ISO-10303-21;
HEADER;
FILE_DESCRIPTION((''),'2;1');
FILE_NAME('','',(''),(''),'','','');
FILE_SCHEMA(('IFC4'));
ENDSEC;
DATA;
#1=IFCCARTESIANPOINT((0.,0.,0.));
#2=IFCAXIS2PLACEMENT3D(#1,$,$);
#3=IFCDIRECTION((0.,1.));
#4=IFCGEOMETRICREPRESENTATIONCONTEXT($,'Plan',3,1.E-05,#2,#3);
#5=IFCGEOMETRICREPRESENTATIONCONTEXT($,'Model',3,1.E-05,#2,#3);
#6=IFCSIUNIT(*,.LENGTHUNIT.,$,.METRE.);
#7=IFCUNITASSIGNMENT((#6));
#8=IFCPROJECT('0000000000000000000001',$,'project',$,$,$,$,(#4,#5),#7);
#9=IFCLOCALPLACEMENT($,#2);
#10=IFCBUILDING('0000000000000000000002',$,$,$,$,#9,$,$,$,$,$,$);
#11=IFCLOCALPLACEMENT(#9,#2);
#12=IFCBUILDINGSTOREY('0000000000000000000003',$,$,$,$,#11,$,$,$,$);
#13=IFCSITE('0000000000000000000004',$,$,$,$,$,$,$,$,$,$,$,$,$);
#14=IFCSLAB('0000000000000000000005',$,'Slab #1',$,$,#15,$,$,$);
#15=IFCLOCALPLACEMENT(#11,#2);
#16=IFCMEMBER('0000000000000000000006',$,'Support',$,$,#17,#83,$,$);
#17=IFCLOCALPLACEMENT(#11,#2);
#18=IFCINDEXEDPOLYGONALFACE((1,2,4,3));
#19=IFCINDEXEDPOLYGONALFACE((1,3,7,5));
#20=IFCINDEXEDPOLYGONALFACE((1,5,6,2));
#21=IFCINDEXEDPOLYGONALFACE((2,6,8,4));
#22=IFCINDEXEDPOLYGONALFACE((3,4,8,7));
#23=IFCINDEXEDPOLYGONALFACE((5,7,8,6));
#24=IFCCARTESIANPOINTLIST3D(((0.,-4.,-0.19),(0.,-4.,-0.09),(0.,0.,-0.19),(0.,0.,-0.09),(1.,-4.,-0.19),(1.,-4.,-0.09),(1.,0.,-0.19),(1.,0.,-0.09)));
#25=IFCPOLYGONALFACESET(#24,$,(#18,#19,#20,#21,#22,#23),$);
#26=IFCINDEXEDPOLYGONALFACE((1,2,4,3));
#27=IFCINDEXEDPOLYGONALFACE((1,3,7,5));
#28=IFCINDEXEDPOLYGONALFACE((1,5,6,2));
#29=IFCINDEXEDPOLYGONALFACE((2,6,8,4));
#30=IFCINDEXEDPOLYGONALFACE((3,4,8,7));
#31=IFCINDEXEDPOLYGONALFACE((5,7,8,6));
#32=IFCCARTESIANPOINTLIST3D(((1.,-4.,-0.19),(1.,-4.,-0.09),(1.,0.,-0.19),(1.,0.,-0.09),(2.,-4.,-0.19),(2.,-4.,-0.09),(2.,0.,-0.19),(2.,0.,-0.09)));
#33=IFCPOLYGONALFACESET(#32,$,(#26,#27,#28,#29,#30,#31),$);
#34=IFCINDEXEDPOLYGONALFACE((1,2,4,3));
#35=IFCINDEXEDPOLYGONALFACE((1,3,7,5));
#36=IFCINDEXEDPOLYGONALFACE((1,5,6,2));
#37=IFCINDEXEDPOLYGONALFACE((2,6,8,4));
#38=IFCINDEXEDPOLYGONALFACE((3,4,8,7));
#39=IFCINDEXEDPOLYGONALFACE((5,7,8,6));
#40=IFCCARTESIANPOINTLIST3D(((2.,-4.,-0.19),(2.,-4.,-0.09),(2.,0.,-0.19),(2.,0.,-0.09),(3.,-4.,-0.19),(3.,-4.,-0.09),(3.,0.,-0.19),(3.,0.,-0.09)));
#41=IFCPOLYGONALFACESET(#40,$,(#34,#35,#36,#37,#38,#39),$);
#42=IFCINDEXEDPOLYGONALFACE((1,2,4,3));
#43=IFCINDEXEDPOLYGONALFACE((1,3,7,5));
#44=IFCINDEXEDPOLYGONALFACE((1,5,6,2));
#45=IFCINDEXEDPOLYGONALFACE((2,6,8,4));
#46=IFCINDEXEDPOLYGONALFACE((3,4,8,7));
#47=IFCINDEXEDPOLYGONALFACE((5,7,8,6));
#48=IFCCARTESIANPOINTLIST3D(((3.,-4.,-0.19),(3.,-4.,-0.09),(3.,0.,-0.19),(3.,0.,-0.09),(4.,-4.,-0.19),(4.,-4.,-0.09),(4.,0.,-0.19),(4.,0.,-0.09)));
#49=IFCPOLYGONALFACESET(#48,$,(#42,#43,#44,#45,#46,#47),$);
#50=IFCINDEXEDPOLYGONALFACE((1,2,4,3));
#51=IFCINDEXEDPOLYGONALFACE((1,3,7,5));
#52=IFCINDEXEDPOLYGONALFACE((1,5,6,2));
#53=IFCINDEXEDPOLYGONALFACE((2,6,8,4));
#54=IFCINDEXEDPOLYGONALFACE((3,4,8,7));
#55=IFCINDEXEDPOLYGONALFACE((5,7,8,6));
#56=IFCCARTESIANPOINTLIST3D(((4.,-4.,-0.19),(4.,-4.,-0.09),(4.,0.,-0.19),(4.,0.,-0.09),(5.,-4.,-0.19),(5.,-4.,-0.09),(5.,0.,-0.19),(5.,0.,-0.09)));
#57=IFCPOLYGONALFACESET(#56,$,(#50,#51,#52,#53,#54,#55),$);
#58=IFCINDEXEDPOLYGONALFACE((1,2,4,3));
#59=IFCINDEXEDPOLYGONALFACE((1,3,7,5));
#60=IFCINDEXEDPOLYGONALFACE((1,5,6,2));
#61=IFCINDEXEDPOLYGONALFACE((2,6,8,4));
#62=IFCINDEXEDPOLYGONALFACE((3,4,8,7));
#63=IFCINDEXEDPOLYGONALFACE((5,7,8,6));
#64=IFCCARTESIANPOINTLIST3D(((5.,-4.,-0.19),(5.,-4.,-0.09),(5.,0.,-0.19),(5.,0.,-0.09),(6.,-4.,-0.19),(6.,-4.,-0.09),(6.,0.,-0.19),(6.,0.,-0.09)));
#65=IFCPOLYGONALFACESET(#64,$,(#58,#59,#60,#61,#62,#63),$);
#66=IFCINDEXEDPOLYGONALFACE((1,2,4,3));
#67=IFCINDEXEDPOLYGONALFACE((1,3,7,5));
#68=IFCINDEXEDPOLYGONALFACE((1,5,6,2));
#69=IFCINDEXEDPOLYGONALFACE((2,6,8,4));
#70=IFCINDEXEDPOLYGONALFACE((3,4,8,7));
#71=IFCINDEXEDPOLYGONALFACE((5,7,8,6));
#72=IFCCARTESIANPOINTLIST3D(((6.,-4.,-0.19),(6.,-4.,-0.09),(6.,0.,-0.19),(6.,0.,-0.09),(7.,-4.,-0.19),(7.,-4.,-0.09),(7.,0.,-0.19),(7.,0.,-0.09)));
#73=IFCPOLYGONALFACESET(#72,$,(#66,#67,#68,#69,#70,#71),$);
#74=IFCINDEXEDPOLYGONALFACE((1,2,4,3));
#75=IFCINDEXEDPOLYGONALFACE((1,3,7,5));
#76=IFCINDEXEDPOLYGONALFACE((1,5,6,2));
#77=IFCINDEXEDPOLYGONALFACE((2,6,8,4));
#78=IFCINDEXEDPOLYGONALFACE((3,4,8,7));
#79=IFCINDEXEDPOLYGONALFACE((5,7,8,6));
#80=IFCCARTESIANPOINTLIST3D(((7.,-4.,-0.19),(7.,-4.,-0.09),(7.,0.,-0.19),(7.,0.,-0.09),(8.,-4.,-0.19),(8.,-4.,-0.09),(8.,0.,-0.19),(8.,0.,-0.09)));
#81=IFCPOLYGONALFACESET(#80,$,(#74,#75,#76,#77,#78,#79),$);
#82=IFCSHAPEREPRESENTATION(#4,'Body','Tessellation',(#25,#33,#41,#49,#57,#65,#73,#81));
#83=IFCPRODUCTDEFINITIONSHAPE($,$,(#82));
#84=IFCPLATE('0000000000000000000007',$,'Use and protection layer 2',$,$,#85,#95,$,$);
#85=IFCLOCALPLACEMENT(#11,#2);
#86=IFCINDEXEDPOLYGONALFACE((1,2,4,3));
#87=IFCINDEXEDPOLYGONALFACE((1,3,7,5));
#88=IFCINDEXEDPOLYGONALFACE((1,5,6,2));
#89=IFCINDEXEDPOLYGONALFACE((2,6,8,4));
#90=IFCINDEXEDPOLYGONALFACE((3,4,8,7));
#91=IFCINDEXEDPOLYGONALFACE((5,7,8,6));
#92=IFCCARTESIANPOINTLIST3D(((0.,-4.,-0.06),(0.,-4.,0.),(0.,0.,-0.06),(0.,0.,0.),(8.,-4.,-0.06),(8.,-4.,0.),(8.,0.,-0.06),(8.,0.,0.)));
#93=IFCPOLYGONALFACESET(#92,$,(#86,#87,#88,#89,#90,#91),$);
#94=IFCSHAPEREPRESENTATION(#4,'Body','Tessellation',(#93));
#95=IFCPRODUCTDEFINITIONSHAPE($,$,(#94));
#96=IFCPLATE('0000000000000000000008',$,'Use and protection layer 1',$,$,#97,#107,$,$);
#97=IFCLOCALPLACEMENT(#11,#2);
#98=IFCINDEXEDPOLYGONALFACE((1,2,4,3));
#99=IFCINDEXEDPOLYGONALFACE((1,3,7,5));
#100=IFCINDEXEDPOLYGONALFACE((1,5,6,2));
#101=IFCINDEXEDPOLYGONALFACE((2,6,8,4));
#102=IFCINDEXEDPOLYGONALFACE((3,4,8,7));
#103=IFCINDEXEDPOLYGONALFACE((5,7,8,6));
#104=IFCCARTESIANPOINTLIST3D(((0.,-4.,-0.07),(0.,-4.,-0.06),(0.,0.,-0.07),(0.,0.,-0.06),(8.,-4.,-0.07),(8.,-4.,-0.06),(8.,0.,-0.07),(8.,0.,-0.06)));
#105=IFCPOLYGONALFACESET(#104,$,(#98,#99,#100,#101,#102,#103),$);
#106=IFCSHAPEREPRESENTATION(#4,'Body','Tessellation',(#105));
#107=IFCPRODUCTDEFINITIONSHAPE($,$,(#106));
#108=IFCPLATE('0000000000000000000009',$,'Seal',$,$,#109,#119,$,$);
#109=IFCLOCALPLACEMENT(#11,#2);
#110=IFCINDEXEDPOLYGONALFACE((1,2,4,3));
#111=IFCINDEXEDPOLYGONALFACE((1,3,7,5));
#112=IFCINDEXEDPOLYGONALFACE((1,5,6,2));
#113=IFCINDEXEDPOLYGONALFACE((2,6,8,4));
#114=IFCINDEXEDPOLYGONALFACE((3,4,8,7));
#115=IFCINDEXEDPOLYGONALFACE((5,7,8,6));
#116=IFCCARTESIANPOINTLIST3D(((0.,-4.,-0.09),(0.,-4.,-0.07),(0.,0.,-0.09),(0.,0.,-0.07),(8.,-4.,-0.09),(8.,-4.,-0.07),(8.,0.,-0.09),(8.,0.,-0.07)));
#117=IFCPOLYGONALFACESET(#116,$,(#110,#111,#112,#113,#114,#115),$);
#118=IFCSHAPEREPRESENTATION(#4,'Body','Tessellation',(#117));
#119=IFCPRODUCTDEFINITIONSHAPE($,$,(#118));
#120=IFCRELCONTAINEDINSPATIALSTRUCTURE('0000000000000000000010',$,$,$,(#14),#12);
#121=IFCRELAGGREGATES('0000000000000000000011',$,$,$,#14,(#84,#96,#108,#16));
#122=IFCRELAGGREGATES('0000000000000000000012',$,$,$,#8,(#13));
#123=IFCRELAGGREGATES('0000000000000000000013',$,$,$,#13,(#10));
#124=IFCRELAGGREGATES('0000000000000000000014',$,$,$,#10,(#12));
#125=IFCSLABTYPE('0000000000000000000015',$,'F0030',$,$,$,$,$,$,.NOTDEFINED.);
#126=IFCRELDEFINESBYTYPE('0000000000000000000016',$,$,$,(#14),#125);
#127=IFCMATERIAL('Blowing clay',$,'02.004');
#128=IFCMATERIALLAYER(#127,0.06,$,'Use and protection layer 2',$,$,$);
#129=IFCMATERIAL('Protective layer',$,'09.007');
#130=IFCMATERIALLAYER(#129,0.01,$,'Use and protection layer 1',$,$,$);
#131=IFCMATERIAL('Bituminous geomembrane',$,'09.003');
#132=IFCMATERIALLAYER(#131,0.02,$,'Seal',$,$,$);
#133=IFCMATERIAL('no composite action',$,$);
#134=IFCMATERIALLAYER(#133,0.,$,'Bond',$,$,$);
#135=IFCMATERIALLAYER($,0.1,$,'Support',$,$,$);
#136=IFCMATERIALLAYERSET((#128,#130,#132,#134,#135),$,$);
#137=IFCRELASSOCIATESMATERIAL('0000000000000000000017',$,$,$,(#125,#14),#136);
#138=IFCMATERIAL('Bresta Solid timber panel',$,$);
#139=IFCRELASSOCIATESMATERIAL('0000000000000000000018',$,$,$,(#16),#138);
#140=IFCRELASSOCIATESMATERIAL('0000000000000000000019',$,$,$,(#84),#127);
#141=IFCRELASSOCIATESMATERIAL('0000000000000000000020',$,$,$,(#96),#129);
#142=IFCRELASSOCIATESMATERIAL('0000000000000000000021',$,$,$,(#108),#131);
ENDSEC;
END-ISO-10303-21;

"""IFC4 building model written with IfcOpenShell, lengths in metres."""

from ifc_helpers import new_model, si_unit, direction, frame, frame_2d, origin, origin_with_axes, place, context, project, spatial, rectangle, extrude, material, layer, layer_set, type_object, element, aggregate, save


model = new_model("IFC4")

# Units and contexts
plan_context = context("Plan", 3, precision=1e-05, world=origin(), true_north=direction((0.0, 1.0)))
model_context = context("Model", 3, precision=1e-05, world=origin(), true_north=direction((0.0, 1.0)))
ifc_project = project(units=[si_unit("LENGTHUNIT", "METRE")], contexts=[plan_context, model_context])

# Site, building, storey
site = spatial("IfcSite", under=ifc_project)
building_placement = place(None, origin())
building = spatial("IfcBuilding", under=site, at=building_placement)
storey_placement = place(building_placement, origin())
storey = spatial("IfcBuildingStorey", under=building, at=storey_placement)

# Slab, member, plates
ifc_material_1 = material(Name="Blowing clay", Category="02.004")
ifc_layer_1 = layer(ifc_material_1, 0.06, Name="Use and protection layer 2")
ifc_material_2 = material(Name="Protective layer", Category="09.007")
ifc_layer_2 = layer(ifc_material_2, 0.01, Name="Use and protection layer 1")
ifc_material_3 = material(Name="Bituminous geomembrane", Category="09.003")
ifc_layer_3 = layer(ifc_material_3, 0.02, Name="Seal")
ifc_material_4 = material(Name="no composite action")
ifc_layer_4 = layer(ifc_material_4, 0.0, Name="Bond")
ifc_layer_5 = layer(None, 0.1, Name="Support")
ifc_layer_set = layer_set([ifc_layer_1, ifc_layer_2, ifc_layer_3, ifc_layer_4, ifc_layer_5])
slab_type = type_object("IfcSlabType", Name="F0030", PredefinedType="NOTDEFINED", material=ifc_layer_set)
slab_placement = place(None, frame((0.0, 0.0, 0.0), z_axis=(0.0, 0.0, -1.0), x_axis=(1.0, 0.0, 0.0)))
slab = element("IfcSlab", 1, at=slab_placement, inside=storey, type_object=slab_type, material=ifc_layer_set, Name="Slab #1")
ifc_material_5 = material(Name="Bresta Solid timber panel")
member_placement = place(slab_placement, origin())
member = element("IfcMember", 2, at=member_placement, material=ifc_material_5, Name="Support", context=plan_context, shape_type="SweptSolid", body=[
    extrude(rectangle(XDim=1.0, YDim=0.1, at=frame_2d((0.5, 0.05), x_axis=(1.0, 0.0))), frame((0.0, 4.0, 0.09), z_axis=(0.0, -1.0, 0.0), x_axis=(1.0, 0.0, 0.0)), (0.0, 0.0, 1.0), 4.0),
    extrude(rectangle(XDim=1.0, YDim=0.1, at=frame_2d((0.5, 0.05), x_axis=(1.0, 0.0))), frame((1.0, 4.0, 0.09), z_axis=(0.0, -1.0, 0.0), x_axis=(1.0, 0.0, 0.0)), (0.0, 0.0, 1.0), 4.0),
    extrude(rectangle(XDim=1.0, YDim=0.1, at=frame_2d((0.5, 0.05), x_axis=(1.0, 0.0))), frame((2.0, 4.0, 0.09), z_axis=(0.0, -1.0, 0.0), x_axis=(1.0, 0.0, 0.0)), (0.0, 0.0, 1.0), 4.0),
    extrude(rectangle(XDim=1.0, YDim=0.1, at=frame_2d((0.5, 0.05), x_axis=(1.0, 0.0))), frame((3.0, 4.0, 0.09), z_axis=(0.0, -1.0, 0.0), x_axis=(1.0, 0.0, 0.0)), (0.0, 0.0, 1.0), 4.0),
    extrude(rectangle(XDim=1.0, YDim=0.1, at=frame_2d((0.5, 0.05), x_axis=(1.0, 0.0))), frame((4.0, 4.0, 0.09), z_axis=(0.0, -1.0, 0.0), x_axis=(1.0, 0.0, 0.0)), (0.0, 0.0, 1.0), 4.0),
    extrude(rectangle(XDim=1.0, YDim=0.1, at=frame_2d((0.5, 0.05), x_axis=(1.0, 0.0))), frame((5.0, 4.0, 0.09), z_axis=(0.0, -1.0, 0.0), x_axis=(1.0, 0.0, 0.0)), (0.0, 0.0, 1.0), 4.0),
    extrude(rectangle(XDim=1.0, YDim=0.1, at=frame_2d((0.5, 0.05), x_axis=(1.0, 0.0))), frame((6.0, 4.0, 0.09), z_axis=(0.0, -1.0, 0.0), x_axis=(1.0, 0.0, 0.0)), (0.0, 0.0, 1.0), 4.0),
    extrude(rectangle(XDim=1.0, YDim=0.1, at=frame_2d((0.5, 0.05), x_axis=(1.0, 0.0))), frame((7.0, 4.0, 0.09), z_axis=(0.0, -1.0, 0.0), x_axis=(1.0, 0.0, 0.0)), (0.0, 0.0, 1.0), 4.0),
])
plate_1_placement = place(slab_placement, origin())
plate_1 = element("IfcPlate", 3, at=plate_1_placement, material=ifc_material_1, Name="Use and protection layer 2", context=plan_context, shape_type="SweptSolid", body=[
    extrude(rectangle(XDim=8.0, YDim=4.0, at=frame_2d((4.0, 2.0), x_axis=(1.0, 0.0))), origin_with_axes(), (0.0, 0.0, 1.0), 0.06),
])
plate_2_placement = place(slab_placement, origin())
plate_2 = element("IfcPlate", 4, at=plate_2_placement, material=ifc_material_2, Name="Use and protection layer 1", context=plan_context, shape_type="SweptSolid", body=[
    extrude(rectangle(XDim=8.0, YDim=4.0, at=frame_2d((4.0, 2.0), x_axis=(1.0, 0.0))), frame((0.0, 0.0, 0.06), z_axis=(0.0, 0.0, 1.0), x_axis=(1.0, 0.0, 0.0)), (0.0, 0.0, 1.0), 0.01),
])
plate_3_placement = place(slab_placement, origin())
plate_3 = element("IfcPlate", 5, at=plate_3_placement, material=ifc_material_3, Name="Seal", context=plan_context, shape_type="SweptSolid", body=[
    extrude(rectangle(XDim=8.0, YDim=4.0, at=frame_2d((4.0, 2.0), x_axis=(1.0, 0.0))), frame((0.0, 0.0, 0.07), z_axis=(0.0, 0.0, 1.0), x_axis=(1.0, 0.0, 0.0)), (0.0, 0.0, 1.0), 0.02),
])
aggregate(slab, [plate_1, plate_2, plate_3, member])

save(model, "model.ifc")
